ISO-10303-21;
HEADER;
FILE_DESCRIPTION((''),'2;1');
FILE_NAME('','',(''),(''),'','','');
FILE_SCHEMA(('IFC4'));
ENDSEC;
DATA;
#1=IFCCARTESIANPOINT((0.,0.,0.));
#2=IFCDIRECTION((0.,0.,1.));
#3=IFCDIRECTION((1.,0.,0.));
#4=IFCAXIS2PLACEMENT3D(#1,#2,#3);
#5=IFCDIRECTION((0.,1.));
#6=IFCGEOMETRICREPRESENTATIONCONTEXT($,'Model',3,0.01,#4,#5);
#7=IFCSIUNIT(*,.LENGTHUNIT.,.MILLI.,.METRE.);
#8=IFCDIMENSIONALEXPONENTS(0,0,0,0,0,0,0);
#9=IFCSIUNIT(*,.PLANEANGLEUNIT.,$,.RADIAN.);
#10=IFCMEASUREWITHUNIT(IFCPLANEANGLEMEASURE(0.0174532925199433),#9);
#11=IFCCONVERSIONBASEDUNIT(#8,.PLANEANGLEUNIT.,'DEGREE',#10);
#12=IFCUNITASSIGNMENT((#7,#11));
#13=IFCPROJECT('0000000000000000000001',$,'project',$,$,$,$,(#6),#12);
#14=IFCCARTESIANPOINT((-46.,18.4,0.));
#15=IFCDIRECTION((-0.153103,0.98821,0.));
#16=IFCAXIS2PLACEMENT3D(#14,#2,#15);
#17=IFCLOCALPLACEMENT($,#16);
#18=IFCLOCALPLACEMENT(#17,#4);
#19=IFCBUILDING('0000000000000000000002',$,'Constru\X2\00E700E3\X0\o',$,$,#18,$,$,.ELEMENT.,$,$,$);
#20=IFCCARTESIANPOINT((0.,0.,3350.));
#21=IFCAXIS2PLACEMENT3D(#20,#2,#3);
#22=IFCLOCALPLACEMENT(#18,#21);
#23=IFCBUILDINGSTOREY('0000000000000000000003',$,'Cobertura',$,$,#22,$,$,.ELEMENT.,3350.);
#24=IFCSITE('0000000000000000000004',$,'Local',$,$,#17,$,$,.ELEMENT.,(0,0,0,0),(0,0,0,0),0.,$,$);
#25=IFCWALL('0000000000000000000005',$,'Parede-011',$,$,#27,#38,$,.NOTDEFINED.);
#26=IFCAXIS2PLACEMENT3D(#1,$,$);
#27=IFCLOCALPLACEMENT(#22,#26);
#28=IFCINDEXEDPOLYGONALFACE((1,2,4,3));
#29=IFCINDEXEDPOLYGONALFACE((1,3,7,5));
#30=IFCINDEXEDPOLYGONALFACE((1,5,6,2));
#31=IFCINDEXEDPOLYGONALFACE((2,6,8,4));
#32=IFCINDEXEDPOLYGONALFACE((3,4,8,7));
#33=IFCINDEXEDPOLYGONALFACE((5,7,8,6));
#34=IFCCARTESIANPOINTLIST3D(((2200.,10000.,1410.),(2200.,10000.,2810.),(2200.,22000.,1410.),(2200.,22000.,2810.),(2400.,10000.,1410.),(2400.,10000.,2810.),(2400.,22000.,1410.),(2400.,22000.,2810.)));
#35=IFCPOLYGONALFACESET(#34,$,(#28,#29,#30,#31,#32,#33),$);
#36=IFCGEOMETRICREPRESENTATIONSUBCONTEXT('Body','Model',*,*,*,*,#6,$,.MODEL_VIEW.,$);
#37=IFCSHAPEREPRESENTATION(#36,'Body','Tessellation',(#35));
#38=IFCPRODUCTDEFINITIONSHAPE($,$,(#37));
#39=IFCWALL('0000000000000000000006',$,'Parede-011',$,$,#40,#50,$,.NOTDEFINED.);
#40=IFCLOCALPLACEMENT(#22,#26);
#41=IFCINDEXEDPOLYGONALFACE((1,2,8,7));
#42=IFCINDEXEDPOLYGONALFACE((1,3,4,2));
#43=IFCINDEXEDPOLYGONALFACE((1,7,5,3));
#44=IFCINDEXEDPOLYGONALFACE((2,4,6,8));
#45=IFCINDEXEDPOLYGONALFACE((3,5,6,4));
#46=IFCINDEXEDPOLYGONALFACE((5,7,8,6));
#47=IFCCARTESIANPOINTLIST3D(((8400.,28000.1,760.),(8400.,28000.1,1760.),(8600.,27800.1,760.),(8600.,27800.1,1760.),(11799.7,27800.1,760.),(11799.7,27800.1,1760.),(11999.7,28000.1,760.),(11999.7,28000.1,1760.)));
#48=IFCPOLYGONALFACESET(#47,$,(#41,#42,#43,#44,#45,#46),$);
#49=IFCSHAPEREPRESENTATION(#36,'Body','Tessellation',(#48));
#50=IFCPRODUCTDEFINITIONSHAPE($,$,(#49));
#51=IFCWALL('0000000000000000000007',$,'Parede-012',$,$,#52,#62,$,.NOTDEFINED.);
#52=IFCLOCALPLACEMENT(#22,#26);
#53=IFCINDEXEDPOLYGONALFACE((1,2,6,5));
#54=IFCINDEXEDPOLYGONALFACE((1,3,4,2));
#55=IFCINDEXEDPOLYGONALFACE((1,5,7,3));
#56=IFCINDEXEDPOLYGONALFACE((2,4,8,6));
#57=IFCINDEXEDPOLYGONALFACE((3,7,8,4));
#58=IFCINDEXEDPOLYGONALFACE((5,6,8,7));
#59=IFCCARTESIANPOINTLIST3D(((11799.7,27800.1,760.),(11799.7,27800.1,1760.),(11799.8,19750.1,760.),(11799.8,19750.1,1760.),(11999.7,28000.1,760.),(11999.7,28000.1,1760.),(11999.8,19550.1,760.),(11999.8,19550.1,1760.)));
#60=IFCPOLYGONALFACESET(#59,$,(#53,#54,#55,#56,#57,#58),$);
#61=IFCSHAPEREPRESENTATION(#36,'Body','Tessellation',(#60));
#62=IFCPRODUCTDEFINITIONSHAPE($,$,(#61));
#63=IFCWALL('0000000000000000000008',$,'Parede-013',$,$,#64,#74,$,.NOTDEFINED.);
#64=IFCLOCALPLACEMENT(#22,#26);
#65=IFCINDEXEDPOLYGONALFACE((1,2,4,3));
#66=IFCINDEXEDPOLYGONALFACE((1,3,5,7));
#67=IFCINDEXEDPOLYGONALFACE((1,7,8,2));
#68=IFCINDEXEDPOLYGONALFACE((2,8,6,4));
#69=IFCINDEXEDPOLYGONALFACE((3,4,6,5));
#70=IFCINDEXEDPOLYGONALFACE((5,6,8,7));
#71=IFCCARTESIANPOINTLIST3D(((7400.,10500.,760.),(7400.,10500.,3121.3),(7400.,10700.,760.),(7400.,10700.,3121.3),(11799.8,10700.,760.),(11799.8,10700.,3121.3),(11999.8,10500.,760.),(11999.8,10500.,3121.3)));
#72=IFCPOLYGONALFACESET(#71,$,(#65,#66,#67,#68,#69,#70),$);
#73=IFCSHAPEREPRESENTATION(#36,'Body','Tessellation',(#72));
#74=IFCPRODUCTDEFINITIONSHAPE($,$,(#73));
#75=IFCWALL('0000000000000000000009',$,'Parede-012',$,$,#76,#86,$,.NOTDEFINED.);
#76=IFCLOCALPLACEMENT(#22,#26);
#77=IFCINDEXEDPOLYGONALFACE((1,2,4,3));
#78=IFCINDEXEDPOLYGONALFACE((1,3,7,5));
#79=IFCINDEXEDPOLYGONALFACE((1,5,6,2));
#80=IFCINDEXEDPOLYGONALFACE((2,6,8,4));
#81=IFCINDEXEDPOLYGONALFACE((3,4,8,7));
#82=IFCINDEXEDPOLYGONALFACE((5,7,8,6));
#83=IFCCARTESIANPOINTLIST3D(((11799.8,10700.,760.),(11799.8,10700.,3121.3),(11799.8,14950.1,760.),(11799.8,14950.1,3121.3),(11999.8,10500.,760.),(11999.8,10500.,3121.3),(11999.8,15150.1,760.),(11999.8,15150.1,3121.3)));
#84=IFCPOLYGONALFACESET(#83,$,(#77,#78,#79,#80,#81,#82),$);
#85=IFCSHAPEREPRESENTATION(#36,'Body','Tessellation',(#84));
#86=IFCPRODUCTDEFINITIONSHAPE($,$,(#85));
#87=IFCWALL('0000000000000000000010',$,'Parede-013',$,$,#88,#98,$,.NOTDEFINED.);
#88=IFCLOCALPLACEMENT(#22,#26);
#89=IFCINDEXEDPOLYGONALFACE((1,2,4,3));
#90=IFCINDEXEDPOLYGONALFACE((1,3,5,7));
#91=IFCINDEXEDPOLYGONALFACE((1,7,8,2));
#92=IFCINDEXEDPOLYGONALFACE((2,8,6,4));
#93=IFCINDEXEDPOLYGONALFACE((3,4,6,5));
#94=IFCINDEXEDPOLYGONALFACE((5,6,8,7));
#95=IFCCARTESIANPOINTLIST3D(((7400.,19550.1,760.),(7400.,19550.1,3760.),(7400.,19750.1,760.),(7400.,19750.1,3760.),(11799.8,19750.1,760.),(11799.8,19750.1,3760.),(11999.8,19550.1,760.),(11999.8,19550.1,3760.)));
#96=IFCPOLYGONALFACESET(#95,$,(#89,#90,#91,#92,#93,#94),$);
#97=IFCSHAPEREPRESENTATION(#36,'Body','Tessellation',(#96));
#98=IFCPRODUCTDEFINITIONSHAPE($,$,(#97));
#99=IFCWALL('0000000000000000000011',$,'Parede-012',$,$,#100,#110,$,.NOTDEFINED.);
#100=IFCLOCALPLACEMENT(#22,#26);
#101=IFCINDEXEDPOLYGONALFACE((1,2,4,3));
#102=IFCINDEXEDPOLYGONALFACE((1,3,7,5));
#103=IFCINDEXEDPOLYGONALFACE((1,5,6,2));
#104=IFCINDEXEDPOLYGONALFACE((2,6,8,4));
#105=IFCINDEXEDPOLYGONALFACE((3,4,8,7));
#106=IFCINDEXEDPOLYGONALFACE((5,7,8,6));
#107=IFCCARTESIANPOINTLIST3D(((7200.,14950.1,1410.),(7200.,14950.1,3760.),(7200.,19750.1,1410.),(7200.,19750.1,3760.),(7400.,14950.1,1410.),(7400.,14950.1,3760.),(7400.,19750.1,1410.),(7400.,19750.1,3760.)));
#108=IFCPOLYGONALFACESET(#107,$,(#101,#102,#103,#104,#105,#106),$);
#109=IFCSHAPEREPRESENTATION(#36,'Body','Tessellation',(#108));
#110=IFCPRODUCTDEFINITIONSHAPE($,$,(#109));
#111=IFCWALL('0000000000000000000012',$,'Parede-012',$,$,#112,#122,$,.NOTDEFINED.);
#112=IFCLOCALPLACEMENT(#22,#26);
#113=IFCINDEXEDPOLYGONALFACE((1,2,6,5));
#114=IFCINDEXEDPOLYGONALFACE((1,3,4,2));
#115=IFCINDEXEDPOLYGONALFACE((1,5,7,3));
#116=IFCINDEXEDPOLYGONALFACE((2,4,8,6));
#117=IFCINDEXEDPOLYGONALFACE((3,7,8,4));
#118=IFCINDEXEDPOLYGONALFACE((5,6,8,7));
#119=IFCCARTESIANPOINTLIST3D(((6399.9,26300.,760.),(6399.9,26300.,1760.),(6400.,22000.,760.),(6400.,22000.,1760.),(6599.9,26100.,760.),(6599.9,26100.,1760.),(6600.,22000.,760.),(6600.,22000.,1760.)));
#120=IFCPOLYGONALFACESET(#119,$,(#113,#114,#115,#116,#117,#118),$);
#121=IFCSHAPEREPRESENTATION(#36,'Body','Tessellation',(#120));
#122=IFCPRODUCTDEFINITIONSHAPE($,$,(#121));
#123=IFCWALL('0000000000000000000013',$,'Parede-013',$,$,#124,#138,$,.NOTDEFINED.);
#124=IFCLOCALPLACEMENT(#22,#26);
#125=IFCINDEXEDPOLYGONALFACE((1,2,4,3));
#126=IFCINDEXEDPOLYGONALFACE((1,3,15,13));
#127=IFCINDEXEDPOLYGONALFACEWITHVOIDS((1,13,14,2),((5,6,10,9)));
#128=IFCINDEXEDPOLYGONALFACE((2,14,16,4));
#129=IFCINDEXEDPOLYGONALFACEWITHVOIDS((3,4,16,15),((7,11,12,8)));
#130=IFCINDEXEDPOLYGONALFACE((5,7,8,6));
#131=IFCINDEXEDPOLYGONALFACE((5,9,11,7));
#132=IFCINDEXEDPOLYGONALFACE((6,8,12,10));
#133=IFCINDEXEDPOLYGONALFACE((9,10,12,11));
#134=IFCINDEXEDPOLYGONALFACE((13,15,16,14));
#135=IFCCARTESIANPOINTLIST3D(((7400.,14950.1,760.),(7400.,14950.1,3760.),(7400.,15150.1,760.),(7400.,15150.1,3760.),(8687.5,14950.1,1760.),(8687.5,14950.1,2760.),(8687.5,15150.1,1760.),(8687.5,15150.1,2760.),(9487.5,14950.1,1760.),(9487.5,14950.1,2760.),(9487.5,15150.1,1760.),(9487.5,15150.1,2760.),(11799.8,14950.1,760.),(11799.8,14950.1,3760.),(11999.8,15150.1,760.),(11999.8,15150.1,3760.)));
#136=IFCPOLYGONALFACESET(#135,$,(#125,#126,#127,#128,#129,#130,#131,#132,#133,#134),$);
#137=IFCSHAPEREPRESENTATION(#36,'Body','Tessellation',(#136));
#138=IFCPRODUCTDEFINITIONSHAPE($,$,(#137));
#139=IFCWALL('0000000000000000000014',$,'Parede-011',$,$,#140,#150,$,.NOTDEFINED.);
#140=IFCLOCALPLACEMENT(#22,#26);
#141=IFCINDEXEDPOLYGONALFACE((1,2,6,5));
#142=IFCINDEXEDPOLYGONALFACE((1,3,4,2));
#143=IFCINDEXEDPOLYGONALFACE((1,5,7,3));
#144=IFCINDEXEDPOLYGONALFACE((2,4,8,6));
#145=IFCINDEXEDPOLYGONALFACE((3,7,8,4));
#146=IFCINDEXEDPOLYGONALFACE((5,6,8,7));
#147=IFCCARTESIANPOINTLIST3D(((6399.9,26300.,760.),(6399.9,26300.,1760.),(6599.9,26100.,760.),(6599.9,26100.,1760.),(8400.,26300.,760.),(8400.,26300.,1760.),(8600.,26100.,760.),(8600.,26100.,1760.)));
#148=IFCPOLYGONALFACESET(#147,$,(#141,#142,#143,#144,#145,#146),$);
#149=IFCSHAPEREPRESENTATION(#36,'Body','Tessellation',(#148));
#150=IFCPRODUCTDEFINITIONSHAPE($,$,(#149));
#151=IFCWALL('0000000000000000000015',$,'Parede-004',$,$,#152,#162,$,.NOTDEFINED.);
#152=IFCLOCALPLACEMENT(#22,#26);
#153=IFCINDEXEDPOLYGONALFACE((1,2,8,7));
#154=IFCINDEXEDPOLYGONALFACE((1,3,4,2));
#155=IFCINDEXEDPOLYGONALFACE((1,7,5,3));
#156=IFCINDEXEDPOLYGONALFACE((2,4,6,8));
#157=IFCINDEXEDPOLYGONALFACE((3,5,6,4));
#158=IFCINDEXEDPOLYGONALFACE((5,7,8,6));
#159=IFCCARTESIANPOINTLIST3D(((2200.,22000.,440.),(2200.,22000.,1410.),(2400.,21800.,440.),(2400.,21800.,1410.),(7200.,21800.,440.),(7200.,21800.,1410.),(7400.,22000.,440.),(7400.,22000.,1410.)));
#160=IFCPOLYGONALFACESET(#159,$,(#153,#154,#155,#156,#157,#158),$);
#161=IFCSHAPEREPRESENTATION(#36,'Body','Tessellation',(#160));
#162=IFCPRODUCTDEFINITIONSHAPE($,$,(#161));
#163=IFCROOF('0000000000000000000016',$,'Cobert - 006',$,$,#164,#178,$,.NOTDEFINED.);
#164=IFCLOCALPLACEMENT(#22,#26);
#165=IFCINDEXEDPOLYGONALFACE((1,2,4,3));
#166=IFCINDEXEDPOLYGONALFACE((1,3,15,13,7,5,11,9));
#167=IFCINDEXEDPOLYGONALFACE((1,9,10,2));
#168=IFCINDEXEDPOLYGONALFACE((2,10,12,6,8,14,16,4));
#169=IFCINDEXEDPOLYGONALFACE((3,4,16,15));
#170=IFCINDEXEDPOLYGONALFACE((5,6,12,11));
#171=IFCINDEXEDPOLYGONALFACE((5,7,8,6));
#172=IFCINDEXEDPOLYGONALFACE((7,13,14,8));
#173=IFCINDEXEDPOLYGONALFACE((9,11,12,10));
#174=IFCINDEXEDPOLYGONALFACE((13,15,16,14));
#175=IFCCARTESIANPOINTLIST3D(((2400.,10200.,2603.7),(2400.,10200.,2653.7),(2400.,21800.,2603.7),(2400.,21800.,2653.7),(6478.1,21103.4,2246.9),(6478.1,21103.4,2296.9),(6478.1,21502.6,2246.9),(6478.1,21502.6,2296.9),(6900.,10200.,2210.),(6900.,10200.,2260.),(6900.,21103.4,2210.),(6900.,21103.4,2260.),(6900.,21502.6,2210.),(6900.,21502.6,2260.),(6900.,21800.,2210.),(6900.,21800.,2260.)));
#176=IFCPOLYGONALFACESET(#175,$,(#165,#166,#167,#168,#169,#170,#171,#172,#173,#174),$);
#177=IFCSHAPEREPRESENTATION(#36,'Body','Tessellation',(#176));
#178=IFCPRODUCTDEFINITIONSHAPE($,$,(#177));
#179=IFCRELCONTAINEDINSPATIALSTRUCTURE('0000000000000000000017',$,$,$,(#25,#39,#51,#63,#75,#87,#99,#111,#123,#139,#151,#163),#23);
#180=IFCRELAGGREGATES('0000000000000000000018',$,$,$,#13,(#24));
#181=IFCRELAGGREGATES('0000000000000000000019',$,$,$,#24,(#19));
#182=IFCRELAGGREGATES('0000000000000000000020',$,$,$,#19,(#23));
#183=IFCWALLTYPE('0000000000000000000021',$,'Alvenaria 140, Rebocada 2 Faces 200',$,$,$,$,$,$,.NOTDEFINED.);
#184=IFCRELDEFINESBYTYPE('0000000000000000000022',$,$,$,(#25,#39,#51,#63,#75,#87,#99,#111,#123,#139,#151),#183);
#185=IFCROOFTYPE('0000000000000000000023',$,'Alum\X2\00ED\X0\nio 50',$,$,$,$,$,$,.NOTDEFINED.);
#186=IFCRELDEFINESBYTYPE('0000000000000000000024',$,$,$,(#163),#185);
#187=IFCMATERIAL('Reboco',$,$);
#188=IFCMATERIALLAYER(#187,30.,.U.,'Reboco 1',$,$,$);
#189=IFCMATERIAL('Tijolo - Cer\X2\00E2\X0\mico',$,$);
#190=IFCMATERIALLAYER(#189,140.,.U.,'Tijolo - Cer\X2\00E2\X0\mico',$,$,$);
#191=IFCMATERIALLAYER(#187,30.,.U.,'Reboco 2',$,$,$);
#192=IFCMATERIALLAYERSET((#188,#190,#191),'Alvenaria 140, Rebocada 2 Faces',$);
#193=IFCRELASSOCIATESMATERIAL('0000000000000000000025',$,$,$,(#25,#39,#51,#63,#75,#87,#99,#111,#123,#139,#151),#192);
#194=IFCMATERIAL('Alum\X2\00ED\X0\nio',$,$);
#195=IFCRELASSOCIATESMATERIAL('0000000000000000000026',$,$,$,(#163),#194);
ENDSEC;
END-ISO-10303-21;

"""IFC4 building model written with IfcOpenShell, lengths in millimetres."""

from ifc_helpers import new_model, entity, si_unit, converted_unit, direction, frame, origin_with_axes, origin_2d_with_axis, place, context, subcontext, project, spatial, line, indexed_curve, rectangle, outline, extrude, material, layer, layer_set, layer_usage, type_object, element, save


model = new_model("IFC4")

# Units and contexts
model_context = context("Model", 3, precision=0.01, world=origin_with_axes(), true_north=direction((0.0, 1.0)))
body_context = subcontext(model_context, "Body", "Model", "MODEL_VIEW")
ifc_project = project(units=[si_unit("LENGTHUNIT", "METRE", prefix="MILLI"), converted_unit("PLANEANGLEUNIT", "DEGREE", entity("IfcPlaneAngleMeasure", 0.0174532925199433), si_unit("PLANEANGLEUNIT", "RADIAN"), dimensions=[0, 0, 0, 0, 0, 0, 0])], contexts=[model_context])

# Site, building, storey
site_placement = place(None, frame((-46.0, 18.4, 0.0), z_axis=(0.0, 0.0, 1.0), x_axis=(-0.153103, 0.98821, 0.0)))
site = spatial("IfcSite", under=ifc_project, at=site_placement, Name="Local", CompositionType="ELEMENT", RefLatitude=(0, 0, 0, 0), RefLongitude=(0, 0, 0, 0), RefElevation=0.0)
building_placement = place(site_placement, origin_with_axes())
building = spatial("IfcBuilding", under=site, at=building_placement, Name="Construção", CompositionType="ELEMENT")
storey_placement = place(building_placement, frame((0.0, 0.0, 3350.0), z_axis=(0.0, 0.0, 1.0), x_axis=(1.0, 0.0, 0.0)))
storey = spatial("IfcBuildingStorey", under=building, at=storey_placement, Name="Cobertura", CompositionType="ELEMENT", Elevation=3350.0)

# Walls
ifc_material_1 = material(Name="Reboco")
ifc_layer_1 = layer(ifc_material_1, 30.0, ventilated="UNKNOWN", Name="Reboco 1")
ifc_material_2 = material(Name="Tijolo - Cerâmico")
ifc_layer_2 = layer(ifc_material_2, 140.0, ventilated="UNKNOWN", Name="Tijolo - Cerâmico")
ifc_layer_3 = layer(ifc_material_1, 30.0, ventilated="UNKNOWN", Name="Reboco 2")
ifc_layer_set_1 = layer_set([ifc_layer_1, ifc_layer_2, ifc_layer_3], Name="Alvenaria 140, Rebocada 2 Faces")
wall_type = type_object("IfcWallType", Name="Alvenaria 140, Rebocada 2 Faces 200", PredefinedType="NOTDEFINED")
ifc_layer_usage_1 = layer_usage(ifc_layer_set_1, "AXIS2", "POSITIVE", 0.0)
wall_1_placement = place(storey_placement, frame((2200.0, 22000.0, 1410.0), z_axis=(0.0, 0.0, 1.0), x_axis=(0.0, -1.0, 0.0)))
element("IfcWall", 1, at=wall_1_placement, inside=storey, type_object=wall_type, material=ifc_layer_usage_1, Name="Parede-011", PredefinedType="NOTDEFINED", context=body_context, shape_type="SweptSolid", body=[
    extrude(outline(indexed_curve([(0.0, 0.0), (12000.0, 0.0), (12000.0, 200.0), (0.0, 200.0)], segments=[line(1, 2, 3, 4, 1)])), origin_with_axes(), (0.0, 0.0, 1.0), 1400.0),
])
ifc_layer_usage_2 = layer_usage(ifc_layer_set_1, "AXIS2", "NEGATIVE", 0.0)
wall_2_placement = place(storey_placement, frame((8400.0, 28000.1, 760.0), z_axis=(0.0, 0.0, 1.0), x_axis=(1.0, 0.0, 0.0)))
element("IfcWall", 2, at=wall_2_placement, inside=storey, type_object=wall_type, material=ifc_layer_usage_2, Name="Parede-011", PredefinedType="NOTDEFINED", context=body_context, shape_type="SweptSolid", body=[
    extrude(outline(indexed_curve([(200.0, -200.0), (3399.7, -200.0), (3599.7, 0.0), (0.0, 0.0)], segments=[line(1, 2, 3, 4, 1)])), origin_with_axes(), (0.0, 0.0, 1.0), 1000.0),
])
ifc_layer_usage_3 = layer_usage(ifc_layer_set_1, "AXIS2", "NEGATIVE", 0.0)
wall_3_placement = place(storey_placement, frame((11999.7, 28000.1, 760.0), z_axis=(0.0, 0.0, 1.0), x_axis=(0.000019, -1.0, 0.0)))
element("IfcWall", 3, at=wall_3_placement, inside=storey, type_object=wall_type, material=ifc_layer_usage_3, Name="Parede-012", PredefinedType="NOTDEFINED", context=body_context, shape_type="SweptSolid", body=[
    extrude(outline(indexed_curve([(200.0, -200.0), (8250.0, -200.0), (8450.0, 0.0), (0.0, 0.0)], segments=[line(1, 2, 3, 4, 1)])), origin_with_axes(), (0.0, 0.0, 1.0), 1000.0),
])
ifc_layer_usage_4 = layer_usage(ifc_layer_set_1, "AXIS2", "NEGATIVE", 0.0)
wall_4_placement = place(storey_placement, frame((11999.8, 10500.0, 760.0), z_axis=(0.0, 0.0, 1.0), x_axis=(-1.0, -0.000002, 0.0)))
element("IfcWall", 4, at=wall_4_placement, inside=storey, type_object=wall_type, material=ifc_layer_usage_4, Name="Parede-013", PredefinedType="NOTDEFINED", context=body_context, shape_type="SweptSolid", body=[
    extrude(outline(indexed_curve([(200.0, -200.0), (4599.8, -200.0), (4599.8, 0.0), (0.0, 0.0)], segments=[line(1, 2, 3, 4, 1)])), origin_with_axes(), (0.0, 0.0, 1.0), 2361.3),
])

# Walls
ifc_layer_usage_5 = layer_usage(ifc_layer_set_1, "AXIS2", "POSITIVE", 0.0)
wall_5_placement = place(storey_placement, frame((11999.8, 10500.0, 760.0), z_axis=(0.0, 0.0, 1.0), x_axis=(0.0, 1.0, 0.0)))
element("IfcWall", 5, at=wall_5_placement, inside=storey, type_object=wall_type, material=ifc_layer_usage_5, Name="Parede-012", PredefinedType="NOTDEFINED", context=body_context, shape_type="SweptSolid", body=[
    extrude(outline(indexed_curve([(0.0, 0.0), (4650.1, 0.0), (4450.1, 200.0), (200.0, 200.0)], segments=[line(1, 2, 3, 4, 1)])), origin_with_axes(), (0.0, 0.0, 1.0), 2361.3),
])
ifc_layer_usage_6 = layer_usage(ifc_layer_set_1, "AXIS2", "POSITIVE", 0.0)
wall_6_placement = place(storey_placement, frame((11999.8, 19750.1, 760.0), z_axis=(0.0, 0.0, 1.0), x_axis=(-1.0, 0.0, 0.0)))
element("IfcWall", 6, at=wall_6_placement, inside=storey, type_object=wall_type, material=ifc_layer_usage_6, Name="Parede-013", PredefinedType="NOTDEFINED", context=body_context, shape_type="SweptSolid", body=[
    extrude(outline(indexed_curve([(200.0, 0.0), (4599.8, 0.0), (4599.8, 200.0), (0.0, 200.0)], segments=[line(1, 2, 3, 4, 1)])), origin_with_axes(), (0.0, 0.0, 1.0), 3000.0),
])
ifc_layer_usage_7 = layer_usage(ifc_layer_set_1, "AXIS2", "POSITIVE", 0.0)
wall_7_placement = place(storey_placement, frame((7400.0, 14950.1, 1410.0), z_axis=(0.0, 0.0, 1.0), x_axis=(0.0, 1.0, 0.0)))
element("IfcWall", 7, at=wall_7_placement, inside=storey, type_object=wall_type, material=ifc_layer_usage_7, Name="Parede-012", PredefinedType="NOTDEFINED", context=body_context, shape_type="SweptSolid", body=[
    extrude(outline(indexed_curve([(0.0, 0.0), (4800.0, 0.0), (4800.0, 200.0), (0.0, 200.0)], segments=[line(1, 2, 3, 4, 1)])), origin_with_axes(), (0.0, 0.0, 1.0), 2350.0),
])
ifc_layer_usage_8 = layer_usage(ifc_layer_set_1, "AXIS2", "POSITIVE", 0.0)
wall_8_placement = place(storey_placement, frame((6399.9, 26300.0, 760.0), z_axis=(0.0, 0.0, 1.0), x_axis=(0.000013, -1.0, 0.0)))
element("IfcWall", 8, at=wall_8_placement, inside=storey, type_object=wall_type, material=ifc_layer_usage_8, Name="Parede-012", PredefinedType="NOTDEFINED", context=body_context, shape_type="SweptSolid", body=[
    extrude(outline(indexed_curve([(0.0, 0.0), (4300.0, 0.0), (4300.0, 200.0), (200.0, 200.0)], segments=[line(1, 2, 3, 4, 1)])), origin_with_axes(), (0.0, 0.0, 1.0), 1000.0),
])

# Wall, opening
ifc_layer_usage_9 = layer_usage(ifc_layer_set_1, "AXIS2", "NEGATIVE", 0.0)
wall_9_placement = place(storey_placement, frame((11999.8, 14950.1, 760.0), z_axis=(0.0, 0.0, 1.0), x_axis=(-1.0, 0.0, 0.0)))
wall_9 = element("IfcWall", 9, at=wall_9_placement, inside=storey, type_object=wall_type, material=ifc_layer_usage_9, Name="Parede-013", PredefinedType="NOTDEFINED", context=body_context, shape_type="SweptSolid", body=[
    extrude(outline(indexed_curve([(0.0, -200.0), (4599.8, -200.0), (4599.8, 0.0), (200.0, 0.0)], segments=[line(1, 2, 3, 4, 1)])), origin_with_axes(), (0.0, 0.0, 1.0), 3000.0),
])
opening_1_placement = place(wall_9_placement, frame((2912.4, 0.0, 1000.0), z_axis=(0.0, 0.0, 1.0), x_axis=(1.0, 0.0, 0.0)))
element("IfcOpeningElement", 10, at=opening_1_placement, cuts=wall_9, context=body_context, shape_type="SweptSolid", body=[
    extrude(rectangle(XDim=800.0, YDim=1000.0, at=origin_2d_with_axis()), frame((0.0, -200.0, 500.0), z_axis=(0.0, -1.0, 0.0), x_axis=(-1.0, 0.0, 0.0)), (0.0, 0.0, -1.0), 600.0),
])

# Walls
ifc_layer_usage_10 = layer_usage(ifc_layer_set_1, "AXIS2", "POSITIVE", 0.0)
wall_10_placement = place(storey_placement, frame((8400.0, 26300.0, 760.0), z_axis=(0.0, 0.0, 1.0), x_axis=(-1.0, 0.0, 0.0)))
element("IfcWall", 11, at=wall_10_placement, inside=storey, type_object=wall_type, material=ifc_layer_usage_10, Name="Parede-011", PredefinedType="NOTDEFINED", context=body_context, shape_type="SweptSolid", body=[
    extrude(outline(indexed_curve([(0.0, 0.0), (2000.0, 0.0), (1800.0, 200.0), (-200.0, 200.0)], segments=[line(1, 2, 3, 4, 1)])), origin_with_axes(), (0.0, 0.0, 1.0), 1000.0),
])
ifc_layer_usage_11 = layer_usage(ifc_layer_set_1, "AXIS2", "NEGATIVE", 0.0)
wall_11_placement = place(storey_placement, frame((2200.0, 22000.0, 440.0), z_axis=(0.0, 0.0, 1.0), x_axis=(1.0, 0.0, 0.0)))
element("IfcWall", 12, at=wall_11_placement, inside=storey, type_object=wall_type, material=ifc_layer_usage_11, Name="Parede-004", PredefinedType="NOTDEFINED", context=body_context, shape_type="SweptSolid", body=[
    extrude(outline(indexed_curve([(200.0, -200.0), (5000.0, -200.0), (5200.0, 0.0), (0.0, 0.0)], segments=[line(1, 2, 3, 4, 1)])), origin_with_axes(), (0.0, 0.0, 1.0), 970.0),
])

# Roof
ifc_material_3 = material(Name="Alumínio")
roof_type = type_object("IfcRoofType", Name="Alumínio 50", PredefinedType="NOTDEFINED")
roof_1_placement = place(storey_placement, frame((6900.0, 21800.0, 2210.0), z_axis=(0.0, 0.0, 1.0), x_axis=(0.0, -1.0, 0.0)))
element("IfcRoof", 13, at=roof_1_placement, inside=storey, type_object=roof_type, material=ifc_material_3, Name="Cobert - 006", PredefinedType="NOTDEFINED", context=body_context, shape_type="SweptSolid", body=[
    extrude(outline(indexed_curve([(0.0, -4517.2), (11600.0, -4517.2), (11600.0, 0.0), (696.6, 0.0), (696.6, -423.5), (297.4, -423.5), (297.4, 0.0), (0.0, 0.0)], segments=[line(1, 2, 3, 4, 5, 6, 7, 8, 1)])), frame((0.0, 0.0, 0.0), z_axis=(0.0, 0.087156, 0.996195), x_axis=(1.0, 0.0, 0.0)), (0.0, -0.087156, 0.996195), 50.0),
])

save(model, "model.ifc")
